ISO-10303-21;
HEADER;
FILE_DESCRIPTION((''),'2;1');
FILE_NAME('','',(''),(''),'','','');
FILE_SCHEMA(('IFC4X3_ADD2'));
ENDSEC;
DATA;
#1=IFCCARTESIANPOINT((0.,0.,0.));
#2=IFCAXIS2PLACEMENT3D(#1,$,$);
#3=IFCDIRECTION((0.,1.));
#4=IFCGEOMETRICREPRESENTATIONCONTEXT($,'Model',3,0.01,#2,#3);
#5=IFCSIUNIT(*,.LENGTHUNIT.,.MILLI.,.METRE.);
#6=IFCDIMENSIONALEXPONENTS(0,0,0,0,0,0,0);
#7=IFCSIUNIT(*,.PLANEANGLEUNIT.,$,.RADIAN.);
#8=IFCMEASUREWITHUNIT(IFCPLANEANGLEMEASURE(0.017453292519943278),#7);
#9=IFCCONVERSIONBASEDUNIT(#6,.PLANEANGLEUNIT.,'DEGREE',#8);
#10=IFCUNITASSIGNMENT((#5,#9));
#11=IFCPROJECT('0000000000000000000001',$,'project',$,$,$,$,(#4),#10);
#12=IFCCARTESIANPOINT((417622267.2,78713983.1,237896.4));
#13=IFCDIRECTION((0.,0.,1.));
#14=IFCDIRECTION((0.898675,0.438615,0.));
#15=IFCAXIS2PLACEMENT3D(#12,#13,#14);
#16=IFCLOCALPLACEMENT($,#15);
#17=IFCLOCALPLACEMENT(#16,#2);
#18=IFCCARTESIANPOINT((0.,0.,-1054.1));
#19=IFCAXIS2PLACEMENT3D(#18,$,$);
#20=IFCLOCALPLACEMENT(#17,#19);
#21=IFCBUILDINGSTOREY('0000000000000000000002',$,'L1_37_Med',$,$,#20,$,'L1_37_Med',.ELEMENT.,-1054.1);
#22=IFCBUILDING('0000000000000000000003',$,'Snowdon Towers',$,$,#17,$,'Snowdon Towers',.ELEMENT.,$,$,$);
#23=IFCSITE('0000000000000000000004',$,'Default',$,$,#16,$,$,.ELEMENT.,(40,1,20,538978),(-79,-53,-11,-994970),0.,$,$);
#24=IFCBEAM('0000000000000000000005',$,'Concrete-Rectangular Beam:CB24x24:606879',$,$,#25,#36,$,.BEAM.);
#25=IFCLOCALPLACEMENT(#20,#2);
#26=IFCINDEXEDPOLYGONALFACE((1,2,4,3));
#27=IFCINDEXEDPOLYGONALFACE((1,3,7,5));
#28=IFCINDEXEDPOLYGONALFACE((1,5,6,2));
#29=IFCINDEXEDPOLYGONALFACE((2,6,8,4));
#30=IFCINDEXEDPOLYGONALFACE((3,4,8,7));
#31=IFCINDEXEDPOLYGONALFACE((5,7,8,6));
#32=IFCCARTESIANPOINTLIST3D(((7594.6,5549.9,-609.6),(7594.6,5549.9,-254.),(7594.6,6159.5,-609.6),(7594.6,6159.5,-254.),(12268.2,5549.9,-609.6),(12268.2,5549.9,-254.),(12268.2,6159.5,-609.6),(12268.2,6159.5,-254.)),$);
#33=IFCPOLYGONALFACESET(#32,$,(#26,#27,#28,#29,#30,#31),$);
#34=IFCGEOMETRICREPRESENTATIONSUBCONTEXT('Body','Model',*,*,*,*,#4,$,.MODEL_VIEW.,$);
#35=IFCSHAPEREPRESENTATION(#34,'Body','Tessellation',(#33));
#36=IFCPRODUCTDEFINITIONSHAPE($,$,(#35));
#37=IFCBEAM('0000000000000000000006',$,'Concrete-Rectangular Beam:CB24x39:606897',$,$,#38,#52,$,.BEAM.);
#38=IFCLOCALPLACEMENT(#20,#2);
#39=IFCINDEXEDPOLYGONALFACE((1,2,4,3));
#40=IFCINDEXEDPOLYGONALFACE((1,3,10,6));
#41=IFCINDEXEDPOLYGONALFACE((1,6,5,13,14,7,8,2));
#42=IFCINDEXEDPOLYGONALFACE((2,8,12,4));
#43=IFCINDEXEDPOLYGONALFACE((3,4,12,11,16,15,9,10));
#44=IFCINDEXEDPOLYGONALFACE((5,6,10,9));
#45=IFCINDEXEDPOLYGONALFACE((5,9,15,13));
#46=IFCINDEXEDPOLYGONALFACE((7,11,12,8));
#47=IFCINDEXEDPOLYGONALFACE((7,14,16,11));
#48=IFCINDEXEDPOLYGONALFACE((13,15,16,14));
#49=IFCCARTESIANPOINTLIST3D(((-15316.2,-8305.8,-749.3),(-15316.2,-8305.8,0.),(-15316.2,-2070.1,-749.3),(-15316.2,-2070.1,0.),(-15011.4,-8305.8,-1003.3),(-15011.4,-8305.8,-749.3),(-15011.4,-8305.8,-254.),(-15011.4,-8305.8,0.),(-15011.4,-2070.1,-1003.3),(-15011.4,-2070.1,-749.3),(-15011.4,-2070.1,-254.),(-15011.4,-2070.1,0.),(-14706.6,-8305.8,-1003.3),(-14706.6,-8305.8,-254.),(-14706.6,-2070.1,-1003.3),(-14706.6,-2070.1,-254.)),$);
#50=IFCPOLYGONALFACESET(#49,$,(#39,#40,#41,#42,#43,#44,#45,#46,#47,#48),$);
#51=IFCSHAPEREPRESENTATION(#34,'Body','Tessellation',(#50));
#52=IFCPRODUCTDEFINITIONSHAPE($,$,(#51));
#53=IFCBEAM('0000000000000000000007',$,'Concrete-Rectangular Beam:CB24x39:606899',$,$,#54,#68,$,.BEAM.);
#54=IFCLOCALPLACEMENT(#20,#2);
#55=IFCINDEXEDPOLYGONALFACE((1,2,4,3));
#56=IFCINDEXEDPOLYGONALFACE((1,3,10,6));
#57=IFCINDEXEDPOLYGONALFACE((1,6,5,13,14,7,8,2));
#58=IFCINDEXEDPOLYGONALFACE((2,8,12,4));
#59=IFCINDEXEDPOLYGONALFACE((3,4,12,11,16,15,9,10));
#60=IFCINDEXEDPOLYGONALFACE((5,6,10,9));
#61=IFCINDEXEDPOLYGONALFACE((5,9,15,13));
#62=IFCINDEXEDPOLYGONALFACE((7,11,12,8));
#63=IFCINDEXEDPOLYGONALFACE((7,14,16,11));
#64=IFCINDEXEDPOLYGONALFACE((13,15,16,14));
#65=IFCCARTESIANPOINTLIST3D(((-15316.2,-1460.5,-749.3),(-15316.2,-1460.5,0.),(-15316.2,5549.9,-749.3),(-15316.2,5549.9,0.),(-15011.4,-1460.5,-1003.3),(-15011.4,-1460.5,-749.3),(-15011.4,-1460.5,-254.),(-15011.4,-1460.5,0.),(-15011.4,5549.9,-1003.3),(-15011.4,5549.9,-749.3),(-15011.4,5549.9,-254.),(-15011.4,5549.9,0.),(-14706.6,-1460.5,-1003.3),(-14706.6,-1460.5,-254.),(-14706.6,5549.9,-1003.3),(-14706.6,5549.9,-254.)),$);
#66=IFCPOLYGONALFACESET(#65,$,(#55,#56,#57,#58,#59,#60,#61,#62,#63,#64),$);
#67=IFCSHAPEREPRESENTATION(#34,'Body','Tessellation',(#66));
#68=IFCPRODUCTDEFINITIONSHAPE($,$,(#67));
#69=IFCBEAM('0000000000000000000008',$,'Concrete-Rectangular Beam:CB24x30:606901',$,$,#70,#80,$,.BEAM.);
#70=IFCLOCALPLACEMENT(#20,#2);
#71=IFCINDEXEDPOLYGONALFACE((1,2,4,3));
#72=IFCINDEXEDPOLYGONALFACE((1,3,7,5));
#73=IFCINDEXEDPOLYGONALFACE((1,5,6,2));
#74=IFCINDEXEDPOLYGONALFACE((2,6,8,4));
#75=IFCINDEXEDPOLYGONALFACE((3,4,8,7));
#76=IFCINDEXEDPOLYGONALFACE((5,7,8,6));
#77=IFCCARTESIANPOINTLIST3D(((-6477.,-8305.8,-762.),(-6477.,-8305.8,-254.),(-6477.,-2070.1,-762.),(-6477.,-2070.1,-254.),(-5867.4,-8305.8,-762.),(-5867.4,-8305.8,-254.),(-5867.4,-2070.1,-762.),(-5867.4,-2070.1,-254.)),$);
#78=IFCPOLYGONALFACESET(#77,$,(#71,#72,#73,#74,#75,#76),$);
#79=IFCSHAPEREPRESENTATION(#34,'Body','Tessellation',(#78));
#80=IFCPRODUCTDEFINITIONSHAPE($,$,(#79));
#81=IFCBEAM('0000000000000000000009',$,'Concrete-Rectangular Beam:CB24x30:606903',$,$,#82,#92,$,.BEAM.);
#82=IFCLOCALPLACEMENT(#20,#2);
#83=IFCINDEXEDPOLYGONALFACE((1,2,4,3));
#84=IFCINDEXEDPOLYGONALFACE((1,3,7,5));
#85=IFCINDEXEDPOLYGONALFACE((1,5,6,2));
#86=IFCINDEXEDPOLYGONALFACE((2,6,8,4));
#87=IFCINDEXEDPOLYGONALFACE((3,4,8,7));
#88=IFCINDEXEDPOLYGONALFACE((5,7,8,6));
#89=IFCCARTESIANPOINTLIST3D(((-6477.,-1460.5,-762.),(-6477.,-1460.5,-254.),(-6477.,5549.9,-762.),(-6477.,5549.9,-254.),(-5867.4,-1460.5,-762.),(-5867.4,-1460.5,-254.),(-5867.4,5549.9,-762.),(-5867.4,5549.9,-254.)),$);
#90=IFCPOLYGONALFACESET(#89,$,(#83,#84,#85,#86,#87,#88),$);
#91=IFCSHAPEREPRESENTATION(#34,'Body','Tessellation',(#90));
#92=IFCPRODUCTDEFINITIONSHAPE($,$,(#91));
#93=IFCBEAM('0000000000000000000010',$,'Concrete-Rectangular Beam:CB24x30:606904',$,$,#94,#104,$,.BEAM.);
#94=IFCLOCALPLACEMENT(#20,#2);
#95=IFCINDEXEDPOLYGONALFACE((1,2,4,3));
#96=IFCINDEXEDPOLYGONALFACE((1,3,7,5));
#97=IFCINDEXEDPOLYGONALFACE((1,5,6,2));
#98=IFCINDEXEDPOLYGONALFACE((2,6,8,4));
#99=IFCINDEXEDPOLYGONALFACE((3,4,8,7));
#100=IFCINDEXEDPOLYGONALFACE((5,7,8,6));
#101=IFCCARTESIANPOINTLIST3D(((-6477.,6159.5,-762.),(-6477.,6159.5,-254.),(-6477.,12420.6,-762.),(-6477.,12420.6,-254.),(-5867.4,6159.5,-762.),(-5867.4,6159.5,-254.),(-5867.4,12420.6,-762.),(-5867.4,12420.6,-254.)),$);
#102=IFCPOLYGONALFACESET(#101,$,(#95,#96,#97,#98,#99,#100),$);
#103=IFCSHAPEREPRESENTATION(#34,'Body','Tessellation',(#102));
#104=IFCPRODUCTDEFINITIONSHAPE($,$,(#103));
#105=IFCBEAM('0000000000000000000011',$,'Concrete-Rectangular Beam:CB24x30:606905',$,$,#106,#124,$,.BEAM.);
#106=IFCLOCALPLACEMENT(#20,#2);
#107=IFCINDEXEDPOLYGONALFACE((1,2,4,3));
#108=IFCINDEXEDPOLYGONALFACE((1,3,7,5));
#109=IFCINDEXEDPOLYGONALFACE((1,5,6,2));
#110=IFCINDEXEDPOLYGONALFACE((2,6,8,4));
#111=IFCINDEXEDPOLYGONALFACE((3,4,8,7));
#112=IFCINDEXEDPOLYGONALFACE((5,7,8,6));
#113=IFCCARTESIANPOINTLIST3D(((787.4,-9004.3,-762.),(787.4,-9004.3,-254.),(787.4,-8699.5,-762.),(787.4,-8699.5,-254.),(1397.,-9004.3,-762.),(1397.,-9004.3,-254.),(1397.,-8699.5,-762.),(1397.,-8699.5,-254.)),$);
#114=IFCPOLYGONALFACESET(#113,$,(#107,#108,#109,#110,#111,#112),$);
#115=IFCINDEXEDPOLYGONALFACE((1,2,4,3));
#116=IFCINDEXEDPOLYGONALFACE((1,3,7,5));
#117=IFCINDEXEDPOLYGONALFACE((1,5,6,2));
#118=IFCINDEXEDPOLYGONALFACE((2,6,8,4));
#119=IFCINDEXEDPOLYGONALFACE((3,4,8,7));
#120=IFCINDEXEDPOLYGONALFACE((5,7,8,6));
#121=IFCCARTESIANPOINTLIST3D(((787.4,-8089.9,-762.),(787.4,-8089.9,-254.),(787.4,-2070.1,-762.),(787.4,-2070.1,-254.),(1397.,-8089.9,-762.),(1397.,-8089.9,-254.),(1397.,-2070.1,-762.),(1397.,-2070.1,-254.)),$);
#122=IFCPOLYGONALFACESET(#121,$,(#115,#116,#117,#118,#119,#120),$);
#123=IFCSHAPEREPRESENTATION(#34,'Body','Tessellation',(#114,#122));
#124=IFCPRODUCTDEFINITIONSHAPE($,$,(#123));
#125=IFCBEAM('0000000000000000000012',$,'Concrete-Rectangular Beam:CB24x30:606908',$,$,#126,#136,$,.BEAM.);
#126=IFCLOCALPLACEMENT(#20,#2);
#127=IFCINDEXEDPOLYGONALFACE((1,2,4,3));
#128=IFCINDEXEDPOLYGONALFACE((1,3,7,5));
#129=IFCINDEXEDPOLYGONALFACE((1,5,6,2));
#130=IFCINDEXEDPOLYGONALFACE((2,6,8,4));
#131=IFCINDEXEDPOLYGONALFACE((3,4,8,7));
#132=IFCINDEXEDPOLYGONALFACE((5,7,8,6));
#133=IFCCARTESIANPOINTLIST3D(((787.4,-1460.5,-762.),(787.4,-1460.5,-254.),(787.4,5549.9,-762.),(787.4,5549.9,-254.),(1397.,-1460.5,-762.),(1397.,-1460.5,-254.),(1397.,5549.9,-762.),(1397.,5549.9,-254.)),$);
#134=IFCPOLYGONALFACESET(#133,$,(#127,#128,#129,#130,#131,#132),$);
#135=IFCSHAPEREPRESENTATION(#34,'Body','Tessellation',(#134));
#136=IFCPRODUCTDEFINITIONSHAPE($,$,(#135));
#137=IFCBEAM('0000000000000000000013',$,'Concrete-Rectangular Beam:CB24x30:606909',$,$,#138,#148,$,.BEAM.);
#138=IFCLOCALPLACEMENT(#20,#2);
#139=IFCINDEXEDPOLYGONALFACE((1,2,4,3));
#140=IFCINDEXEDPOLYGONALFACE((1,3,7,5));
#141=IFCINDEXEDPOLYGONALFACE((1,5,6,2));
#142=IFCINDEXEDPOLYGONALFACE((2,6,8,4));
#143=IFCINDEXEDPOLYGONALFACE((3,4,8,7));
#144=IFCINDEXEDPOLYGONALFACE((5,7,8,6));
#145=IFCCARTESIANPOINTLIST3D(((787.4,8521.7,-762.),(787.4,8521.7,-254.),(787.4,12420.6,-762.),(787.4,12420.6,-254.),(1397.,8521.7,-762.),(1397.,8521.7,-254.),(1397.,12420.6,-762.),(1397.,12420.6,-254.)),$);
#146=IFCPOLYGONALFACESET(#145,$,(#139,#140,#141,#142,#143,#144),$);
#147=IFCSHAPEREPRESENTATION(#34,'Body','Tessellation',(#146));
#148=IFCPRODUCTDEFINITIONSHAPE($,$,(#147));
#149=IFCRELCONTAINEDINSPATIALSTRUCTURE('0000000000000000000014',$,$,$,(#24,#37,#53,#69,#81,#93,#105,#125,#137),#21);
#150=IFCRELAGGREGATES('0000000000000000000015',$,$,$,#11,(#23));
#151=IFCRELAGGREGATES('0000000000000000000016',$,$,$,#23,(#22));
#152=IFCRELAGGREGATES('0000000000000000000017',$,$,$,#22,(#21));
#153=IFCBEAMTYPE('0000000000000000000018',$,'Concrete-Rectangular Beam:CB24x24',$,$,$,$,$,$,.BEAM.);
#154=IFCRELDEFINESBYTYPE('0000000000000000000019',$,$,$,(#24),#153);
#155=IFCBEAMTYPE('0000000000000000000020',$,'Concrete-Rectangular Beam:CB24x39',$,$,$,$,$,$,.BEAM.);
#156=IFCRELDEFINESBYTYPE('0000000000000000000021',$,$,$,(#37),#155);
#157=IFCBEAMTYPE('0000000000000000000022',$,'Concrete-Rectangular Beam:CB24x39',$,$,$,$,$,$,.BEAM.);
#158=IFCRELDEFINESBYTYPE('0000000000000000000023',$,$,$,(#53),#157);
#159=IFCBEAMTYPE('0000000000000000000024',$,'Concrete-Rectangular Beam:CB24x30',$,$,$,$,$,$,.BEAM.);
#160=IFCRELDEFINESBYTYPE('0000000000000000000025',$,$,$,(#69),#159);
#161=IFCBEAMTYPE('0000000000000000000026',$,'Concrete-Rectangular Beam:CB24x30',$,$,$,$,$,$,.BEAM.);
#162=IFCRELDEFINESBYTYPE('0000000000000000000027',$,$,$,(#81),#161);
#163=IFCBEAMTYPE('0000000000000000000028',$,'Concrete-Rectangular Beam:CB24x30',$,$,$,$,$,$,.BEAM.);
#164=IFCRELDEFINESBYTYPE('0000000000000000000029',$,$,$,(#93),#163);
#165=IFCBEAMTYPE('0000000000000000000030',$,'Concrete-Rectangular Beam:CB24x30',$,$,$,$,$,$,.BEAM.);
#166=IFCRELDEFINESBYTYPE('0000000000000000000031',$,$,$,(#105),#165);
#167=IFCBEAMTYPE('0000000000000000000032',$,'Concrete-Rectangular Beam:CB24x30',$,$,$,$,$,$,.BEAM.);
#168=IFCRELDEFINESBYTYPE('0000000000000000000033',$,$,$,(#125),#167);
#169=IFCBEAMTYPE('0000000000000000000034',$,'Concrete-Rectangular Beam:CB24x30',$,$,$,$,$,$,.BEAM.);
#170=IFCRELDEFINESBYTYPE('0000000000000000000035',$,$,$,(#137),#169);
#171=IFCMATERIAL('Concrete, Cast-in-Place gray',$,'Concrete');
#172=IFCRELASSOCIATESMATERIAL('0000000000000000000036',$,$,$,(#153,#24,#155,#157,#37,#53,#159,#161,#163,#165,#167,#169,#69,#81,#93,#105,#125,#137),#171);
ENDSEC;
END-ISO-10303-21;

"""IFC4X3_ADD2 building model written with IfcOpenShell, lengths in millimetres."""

from ifc_helpers import new_model, entity, si_unit, converted_unit, direction, frame, frame_2d, origin, place, context, subcontext, project, spatial, polyline, rectangle, outline, extrude, source, transform, mapped, material, material_profile, profile_set, profile_usage, type_object, type_shapes, element, save


model = new_model("IFC4X3_ADD2")

# Units and contexts
model_context = context("Model", 3, precision=0.01, world=origin(), true_north=direction((0.0, 1.0)))
body_context = subcontext(model_context, "Body", "Model", "MODEL_VIEW")
ifc_project = project(units=[si_unit("LENGTHUNIT", "METRE", prefix="MILLI"), converted_unit("PLANEANGLEUNIT", "DEGREE", entity("IfcPlaneAngleMeasure", 0.017453292519943278), si_unit("PLANEANGLEUNIT", "RADIAN"), dimensions=[0, 0, 0, 0, 0, 0, 0])], contexts=[model_context])

# Site, building, storey
site_placement = place(None, frame((417622267.2, 78713983.1, 237896.4), z_axis=(0.0, 0.0, 1.0), x_axis=(0.898675, 0.438615, 0.0)))
site = spatial("IfcSite", under=ifc_project, at=site_placement, Name="Default", CompositionType="ELEMENT", RefLatitude=(40, 1, 20, 538978), RefLongitude=(-79, -53, -11, -994970), RefElevation=0.0)
building_placement = place(site_placement, origin())
building = spatial("IfcBuilding", under=site, at=building_placement, Name="Snowdon Towers", LongName="Snowdon Towers", CompositionType="ELEMENT")
storey_placement = place(building_placement, frame((0.0, 0.0, -1054.1)))
storey = spatial("IfcBuildingStorey", under=building, at=storey_placement, Name="L1_37_Med", LongName="L1_37_Med", CompositionType="ELEMENT", Elevation=-1054.1)

# Beams
ifc_material_1 = material(Name="Concrete, Cast-in-Place gray", Category="Concrete")
ifc_material_profile_1 = material_profile(ifc_material_1, rectangle(XDim=355.6, YDim=609.6, at=frame_2d((0.0, 0.0), x_axis=(1.0, 0.0))), Name="CB24x24")
ifc_profile_set_1 = profile_set([ifc_material_profile_1], Name="CB24x24")
ifc_profile_usage_1 = profile_usage(ifc_profile_set_1, cardinal=8)
beam_type_1 = type_object("IfcBeamType", Name="Concrete-Rectangular Beam:CB24x24", PredefinedType="BEAM", material=ifc_profile_set_1)
shared_shape_1 = source(origin(), body_context, "Body", "SweptSolid", [
    extrude(rectangle(XDim=355.6, YDim=609.6, at=frame_2d((0.0, 0.0), x_axis=(1.0, 0.0))), frame((7594.6, 5854.7, -1485.9), z_axis=(1.0, 0.0, 0.0), x_axis=(0.0, 0.0, -1.0)), (0.0, 0.0, 1.0), 4673.6),
])
type_shapes(beam_type_1, [shared_shape_1])
beam_1_placement = place(storey_placement, frame((0.0, 0.0, 1054.1)))
element("IfcBeam", 1, at=beam_1_placement, inside=storey, type_object=beam_type_1, material=ifc_profile_usage_1, Name="Concrete-Rectangular Beam:CB24x24:606879", PredefinedType="BEAM", context=body_context, shape_type="MappedRepresentation", body=[
    mapped(shared_shape_1, transform((0.0, 0.0, 0.0), scale=1.0)),
])
ifc_material_profile_2 = material_profile(ifc_material_1, outline(polyline([(-304.8, -501.6), (0.0, -501.6), (0.0, -247.7), (304.8, -247.7), (304.8, 501.7), (0.0, 501.7), (0.0, 247.7), (-304.8, 247.7), (-304.8, -501.6)])), Name="CB24x39")
ifc_profile_set_2 = profile_set([ifc_material_profile_2], Name="CB24x39")
ifc_profile_usage_2 = profile_usage(ifc_profile_set_2, cardinal=8)
beam_type_2 = type_object("IfcBeamType", Name="Concrete-Rectangular Beam:CB24x39", PredefinedType="BEAM", material=ifc_profile_set_2)
shared_shape_2 = source(origin(), body_context, "Body", "SweptSolid", [
    extrude(outline(polyline([(-304.8, -501.6), (0.0, -501.6), (0.0, -247.7), (304.8, -247.7), (304.8, 501.7), (0.0, 501.7), (0.0, 247.7), (-304.8, 247.7), (-304.8, -501.6)])), frame((-15011.4, -8305.8, -1555.8), z_axis=(0.0, 1.0, 0.0), x_axis=(-1.0, 0.0, 0.0)), (0.0, 0.0, 1.0), 6235.7),
])
type_shapes(beam_type_2, [shared_shape_2])
beam_2_placement = place(storey_placement, frame((0.0, 0.0, 1054.1)))
element("IfcBeam", 2, at=beam_2_placement, inside=storey, type_object=beam_type_2, material=ifc_profile_usage_2, Name="Concrete-Rectangular Beam:CB24x39:606897", PredefinedType="BEAM", context=body_context, shape_type="MappedRepresentation", body=[
    mapped(shared_shape_2, transform((0.0, 0.0, 0.0), scale=1.0)),
])
beam_type_3 = type_object("IfcBeamType", Name="Concrete-Rectangular Beam:CB24x39", PredefinedType="BEAM", material=ifc_profile_set_2)
shared_shape_3 = source(origin(), body_context, "Body", "SweptSolid", [
    extrude(outline(polyline([(-304.8, -501.6), (0.0, -501.6), (0.0, -247.7), (304.8, -247.7), (304.8, 501.7), (0.0, 501.7), (0.0, 247.7), (-304.8, 247.7), (-304.8, -501.6)])), frame((-15011.4, -1460.5, -1555.8), z_axis=(0.0, 1.0, 0.0), x_axis=(-1.0, 0.0, 0.0)), (0.0, 0.0, 1.0), 7010.4),
])
type_shapes(beam_type_3, [shared_shape_3])
beam_3_placement = place(storey_placement, frame((0.0, 0.0, 1054.1)))
element("IfcBeam", 3, at=beam_3_placement, inside=storey, type_object=beam_type_3, material=ifc_profile_usage_2, Name="Concrete-Rectangular Beam:CB24x39:606899", PredefinedType="BEAM", context=body_context, shape_type="MappedRepresentation", body=[
    mapped(shared_shape_3, transform((0.0, 0.0, 0.0), scale=1.0)),
])
ifc_material_profile_3 = material_profile(ifc_material_1, rectangle(XDim=508.0, YDim=609.6, at=frame_2d((0.0, 0.0), x_axis=(0.0, 1.0))), Name="CB24x30")
ifc_profile_set_3 = profile_set([ifc_material_profile_3], Name="CB24x30")
ifc_profile_usage_3 = profile_usage(ifc_profile_set_3, cardinal=8)
beam_type_4 = type_object("IfcBeamType", Name="Concrete-Rectangular Beam:CB24x30", PredefinedType="BEAM", material=ifc_profile_set_3)
shared_shape_4 = source(origin(), body_context, "Body", "SweptSolid", [
    extrude(rectangle(XDim=508.0, YDim=609.6, at=frame_2d((0.0, 0.0), x_axis=(0.0, 1.0))), frame((-6172.2, -8305.8, -1562.1), z_axis=(0.0, 1.0, 0.0), x_axis=(-1.0, 0.0, 0.0)), (0.0, 0.0, 1.0), 6235.7),
])
type_shapes(beam_type_4, [shared_shape_4])
beam_4_placement = place(storey_placement, frame((0.0, 0.0, 1054.1)))
element("IfcBeam", 4, at=beam_4_placement, inside=storey, type_object=beam_type_4, material=ifc_profile_usage_3, Name="Concrete-Rectangular Beam:CB24x30:606901", PredefinedType="BEAM", context=body_context, shape_type="MappedRepresentation", body=[
    mapped(shared_shape_4, transform((0.0, 0.0, 0.0), scale=1.0)),
])
beam_type_5 = type_object("IfcBeamType", Name="Concrete-Rectangular Beam:CB24x30", PredefinedType="BEAM", material=ifc_profile_set_3)
shared_shape_5 = source(origin(), body_context, "Body", "SweptSolid", [
    extrude(rectangle(XDim=508.0, YDim=609.6, at=frame_2d((0.0, 0.0), x_axis=(0.0, 1.0))), frame((-6172.2, -1460.5, -1562.1), z_axis=(0.0, 1.0, 0.0), x_axis=(-1.0, 0.0, 0.0)), (0.0, 0.0, 1.0), 7010.4),
])
type_shapes(beam_type_5, [shared_shape_5])
beam_5_placement = place(storey_placement, frame((0.0, 0.0, 1054.1)))
element("IfcBeam", 5, at=beam_5_placement, inside=storey, type_object=beam_type_5, material=ifc_profile_usage_3, Name="Concrete-Rectangular Beam:CB24x30:606903", PredefinedType="BEAM", context=body_context, shape_type="MappedRepresentation", body=[
    mapped(shared_shape_5, transform((0.0, 0.0, 0.0), scale=1.0)),
])
beam_type_6 = type_object("IfcBeamType", Name="Concrete-Rectangular Beam:CB24x30", PredefinedType="BEAM", material=ifc_profile_set_3)
shared_shape_6 = source(origin(), body_context, "Body", "SweptSolid", [
    extrude(rectangle(XDim=508.0, YDim=609.6, at=frame_2d((0.0, 0.0), x_axis=(0.0, 1.0))), frame((-6172.2, 6159.5, -1562.1), z_axis=(0.0, 1.0, 0.0), x_axis=(-1.0, 0.0, 0.0)), (0.0, 0.0, 1.0), 6261.1),
])
type_shapes(beam_type_6, [shared_shape_6])
beam_6_placement = place(storey_placement, frame((0.0, 0.0, 1054.1)))
element("IfcBeam", 6, at=beam_6_placement, inside=storey, type_object=beam_type_6, material=ifc_profile_usage_3, Name="Concrete-Rectangular Beam:CB24x30:606904", PredefinedType="BEAM", context=body_context, shape_type="MappedRepresentation", body=[
    mapped(shared_shape_6, transform((0.0, 0.0, 0.0), scale=1.0)),
])
beam_type_7 = type_object("IfcBeamType", Name="Concrete-Rectangular Beam:CB24x30", PredefinedType="BEAM", material=ifc_profile_set_3)
shared_shape_7 = source(origin(), body_context, "Body", "SweptSolid", [
    extrude(rectangle(XDim=508.0, YDim=609.6, at=frame_2d((0.0, 0.0), x_axis=(0.0, 1.0))), frame((1092.2, -9004.3, -1562.1), z_axis=(0.0, 1.0, 0.0), x_axis=(-1.0, 0.0, 0.0)), (0.0, 0.0, 1.0), 304.8),
    extrude(rectangle(XDim=508.0, YDim=609.6, at=frame_2d((0.0, 0.0), x_axis=(0.0, 1.0))), frame((1092.2, -8089.9, -1562.1), z_axis=(0.0, 1.0, 0.0), x_axis=(-1.0, 0.0, 0.0)), (0.0, 0.0, 1.0), 6019.8),
])
type_shapes(beam_type_7, [shared_shape_7])
beam_7_placement = place(storey_placement, frame((0.0, 0.0, 1054.1)))
element("IfcBeam", 7, at=beam_7_placement, inside=storey, type_object=beam_type_7, material=ifc_profile_usage_3, Name="Concrete-Rectangular Beam:CB24x30:606905", PredefinedType="BEAM", context=body_context, shape_type="MappedRepresentation", body=[
    mapped(shared_shape_7, transform((0.0, 0.0, 0.0), scale=1.0)),
])
beam_type_8 = type_object("IfcBeamType", Name="Concrete-Rectangular Beam:CB24x30", PredefinedType="BEAM", material=ifc_profile_set_3)
shared_shape_8 = source(origin(), body_context, "Body", "SweptSolid", [
    extrude(rectangle(XDim=508.0, YDim=609.6, at=frame_2d((0.0, 0.0), x_axis=(0.0, 1.0))), frame((1092.2, -1460.5, -1562.1), z_axis=(0.0, 1.0, 0.0), x_axis=(-1.0, 0.0, 0.0)), (0.0, 0.0, 1.0), 7010.4),
])
type_shapes(beam_type_8, [shared_shape_8])
beam_8_placement = place(storey_placement, frame((0.0, 0.0, 1054.1)))
element("IfcBeam", 8, at=beam_8_placement, inside=storey, type_object=beam_type_8, material=ifc_profile_usage_3, Name="Concrete-Rectangular Beam:CB24x30:606908", PredefinedType="BEAM", context=body_context, shape_type="MappedRepresentation", body=[
    mapped(shared_shape_8, transform((0.0, 0.0, 0.0), scale=1.0)),
])
beam_type_9 = type_object("IfcBeamType", Name="Concrete-Rectangular Beam:CB24x30", PredefinedType="BEAM", material=ifc_profile_set_3)
shared_shape_9 = source(origin(), body_context, "Body", "SweptSolid", [
    extrude(rectangle(XDim=508.0, YDim=609.6, at=frame_2d((0.0, 0.0), x_axis=(0.0, 1.0))), frame((1092.2, 8521.7, -1562.1), z_axis=(0.0, 1.0, 0.0), x_axis=(-1.0, 0.0, 0.0)), (0.0, 0.0, 1.0), 3898.9),
])
type_shapes(beam_type_9, [shared_shape_9])
beam_9_placement = place(storey_placement, frame((0.0, 0.0, 1054.1)))
element("IfcBeam", 9, at=beam_9_placement, inside=storey, type_object=beam_type_9, material=ifc_profile_usage_3, Name="Concrete-Rectangular Beam:CB24x30:606909", PredefinedType="BEAM", context=body_context, shape_type="MappedRepresentation", body=[
    mapped(shared_shape_9, transform((0.0, 0.0, 0.0), scale=1.0)),
])

save(model, "model.ifc")
